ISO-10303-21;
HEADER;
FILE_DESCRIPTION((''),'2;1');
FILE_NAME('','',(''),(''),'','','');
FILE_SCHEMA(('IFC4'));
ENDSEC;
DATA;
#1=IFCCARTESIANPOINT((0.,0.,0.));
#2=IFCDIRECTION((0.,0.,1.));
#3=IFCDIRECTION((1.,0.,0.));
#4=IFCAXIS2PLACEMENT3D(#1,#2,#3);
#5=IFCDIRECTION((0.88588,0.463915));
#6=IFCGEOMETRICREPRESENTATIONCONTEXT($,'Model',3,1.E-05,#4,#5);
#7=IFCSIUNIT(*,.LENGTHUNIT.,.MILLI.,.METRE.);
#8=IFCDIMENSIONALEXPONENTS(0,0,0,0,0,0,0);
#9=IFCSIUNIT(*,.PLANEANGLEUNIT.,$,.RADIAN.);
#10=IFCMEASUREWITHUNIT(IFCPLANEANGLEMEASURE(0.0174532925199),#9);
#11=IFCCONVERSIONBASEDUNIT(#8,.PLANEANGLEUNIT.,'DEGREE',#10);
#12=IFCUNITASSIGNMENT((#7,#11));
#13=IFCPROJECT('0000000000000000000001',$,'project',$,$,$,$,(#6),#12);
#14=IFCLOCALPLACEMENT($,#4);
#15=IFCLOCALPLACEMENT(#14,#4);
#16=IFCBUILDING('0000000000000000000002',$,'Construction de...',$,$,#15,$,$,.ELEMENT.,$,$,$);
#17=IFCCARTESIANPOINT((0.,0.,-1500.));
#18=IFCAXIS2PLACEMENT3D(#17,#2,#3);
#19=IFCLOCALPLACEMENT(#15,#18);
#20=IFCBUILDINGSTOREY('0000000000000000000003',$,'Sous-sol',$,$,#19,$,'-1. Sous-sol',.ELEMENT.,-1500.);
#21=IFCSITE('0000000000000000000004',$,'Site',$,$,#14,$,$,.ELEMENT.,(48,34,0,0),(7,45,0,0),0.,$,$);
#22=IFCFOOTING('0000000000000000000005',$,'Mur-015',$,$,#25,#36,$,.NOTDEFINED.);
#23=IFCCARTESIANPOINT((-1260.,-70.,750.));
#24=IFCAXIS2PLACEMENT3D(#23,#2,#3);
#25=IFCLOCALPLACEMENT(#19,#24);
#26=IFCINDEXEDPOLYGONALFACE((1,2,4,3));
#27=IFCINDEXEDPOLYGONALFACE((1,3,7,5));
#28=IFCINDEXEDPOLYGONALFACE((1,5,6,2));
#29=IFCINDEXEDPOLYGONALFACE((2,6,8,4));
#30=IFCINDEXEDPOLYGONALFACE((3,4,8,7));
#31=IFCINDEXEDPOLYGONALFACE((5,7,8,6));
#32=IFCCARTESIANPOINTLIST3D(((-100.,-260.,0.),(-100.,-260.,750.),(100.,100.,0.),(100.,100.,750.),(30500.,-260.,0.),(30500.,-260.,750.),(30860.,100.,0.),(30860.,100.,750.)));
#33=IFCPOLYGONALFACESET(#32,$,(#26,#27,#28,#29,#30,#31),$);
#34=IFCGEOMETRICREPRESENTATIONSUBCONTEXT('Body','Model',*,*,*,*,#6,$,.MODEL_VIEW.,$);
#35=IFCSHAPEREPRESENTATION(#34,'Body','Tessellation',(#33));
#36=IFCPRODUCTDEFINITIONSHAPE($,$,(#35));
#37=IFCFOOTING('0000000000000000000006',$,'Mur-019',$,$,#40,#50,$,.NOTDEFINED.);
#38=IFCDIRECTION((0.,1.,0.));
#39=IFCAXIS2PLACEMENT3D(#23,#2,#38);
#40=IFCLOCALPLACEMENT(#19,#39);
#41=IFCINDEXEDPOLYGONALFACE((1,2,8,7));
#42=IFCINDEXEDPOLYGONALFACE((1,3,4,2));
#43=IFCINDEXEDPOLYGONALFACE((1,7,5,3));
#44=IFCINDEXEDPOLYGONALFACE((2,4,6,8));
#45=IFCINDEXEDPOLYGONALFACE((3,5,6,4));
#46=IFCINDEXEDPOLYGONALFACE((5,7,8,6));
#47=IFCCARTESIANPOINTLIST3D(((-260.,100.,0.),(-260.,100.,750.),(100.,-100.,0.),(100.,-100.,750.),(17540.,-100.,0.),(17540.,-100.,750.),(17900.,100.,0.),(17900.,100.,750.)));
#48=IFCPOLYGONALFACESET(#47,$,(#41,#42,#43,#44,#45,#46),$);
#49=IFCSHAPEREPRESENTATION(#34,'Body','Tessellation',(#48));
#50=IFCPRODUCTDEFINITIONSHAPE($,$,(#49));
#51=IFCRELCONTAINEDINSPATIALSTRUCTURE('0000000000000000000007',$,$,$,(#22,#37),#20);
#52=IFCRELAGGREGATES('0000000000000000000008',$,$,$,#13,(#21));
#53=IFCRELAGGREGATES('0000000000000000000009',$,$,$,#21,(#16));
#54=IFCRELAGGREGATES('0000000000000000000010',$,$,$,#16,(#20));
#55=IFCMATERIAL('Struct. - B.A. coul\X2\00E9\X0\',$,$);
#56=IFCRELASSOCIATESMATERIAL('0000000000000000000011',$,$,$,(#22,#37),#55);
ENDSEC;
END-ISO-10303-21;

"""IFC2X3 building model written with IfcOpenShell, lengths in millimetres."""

from ifc_helpers import new_model, entity, si_unit, converted_unit, direction, frame, origin_with_axes, place, context, subcontext, project, spatial, polyline, outline, extrude, material, element, save


model = new_model("IFC2X3")

# Units and contexts
model_context = context("Model", 3, precision=1e-05, world=origin_with_axes(), true_north=direction((0.88588, 0.463915)))
body_context = subcontext(model_context, "Body", "Model", "MODEL_VIEW")
ifc_project = project(units=[si_unit("LENGTHUNIT", "METRE", prefix="MILLI"), converted_unit("PLANEANGLEUNIT", "DEGREE", entity("IfcPlaneAngleMeasure", 0.0174532925199), si_unit("PLANEANGLEUNIT", "RADIAN"), dimensions=[0, 0, 0, 0, 0, 0, 0])], contexts=[model_context])

# Site, building, storey
site_placement = place(None, origin_with_axes())
site = spatial("IfcSite", under=ifc_project, at=site_placement, Name="Site", CompositionType="ELEMENT", RefLatitude=(48, 34, 0, 0), RefLongitude=(7, 45, 0, 0), RefElevation=0.0)
building_placement = place(site_placement, origin_with_axes())
building = spatial("IfcBuilding", under=site, at=building_placement, Name="Construction de...", CompositionType="ELEMENT")
storey_placement = place(building_placement, frame((0.0, 0.0, -1500.0), z_axis=(0.0, 0.0, 1.0), x_axis=(1.0, 0.0, 0.0)))
storey = spatial("IfcBuildingStorey", under=building, at=storey_placement, Name="Sous-sol", LongName="-1. Sous-sol", CompositionType="ELEMENT", Elevation=-1500.0)

# Footings
ifc_material_1 = material(Name="Struct. - B.A. coulé")
footing_1_placement = place(storey_placement, frame((-1260.0, -70.0, 750.0), z_axis=(0.0, 0.0, 1.0), x_axis=(1.0, 0.0, 0.0)))
element("IfcFooting", 1, at=footing_1_placement, inside=storey, material=ifc_material_1, Name="Mur-015", PredefinedType="NOTDEFINED", context=body_context, shape_type="SweptSolid", body=[
    extrude(outline(polyline([(-100.0, -260.0), (30500.0, -260.0), (30860.0, 100.0), (100.0, 100.0), (-100.0, -260.0)])), origin_with_axes(), (0.0, 0.0, 1.0), 750.0),
])
footing_2_placement = place(storey_placement, frame((-1260.0, -70.0, 750.0), z_axis=(0.0, 0.0, 1.0), x_axis=(0.0, 1.0, 0.0)))
element("IfcFooting", 2, at=footing_2_placement, inside=storey, material=ifc_material_1, Name="Mur-019", PredefinedType="NOTDEFINED", context=body_context, shape_type="SweptSolid", body=[
    extrude(outline(polyline([(100.0, -100.0), (17540.0, -100.0), (17900.0, 100.0), (-260.0, 100.0), (100.0, -100.0)])), origin_with_axes(), (0.0, 0.0, 1.0), 750.0),
])

save(model, "model.ifc")
